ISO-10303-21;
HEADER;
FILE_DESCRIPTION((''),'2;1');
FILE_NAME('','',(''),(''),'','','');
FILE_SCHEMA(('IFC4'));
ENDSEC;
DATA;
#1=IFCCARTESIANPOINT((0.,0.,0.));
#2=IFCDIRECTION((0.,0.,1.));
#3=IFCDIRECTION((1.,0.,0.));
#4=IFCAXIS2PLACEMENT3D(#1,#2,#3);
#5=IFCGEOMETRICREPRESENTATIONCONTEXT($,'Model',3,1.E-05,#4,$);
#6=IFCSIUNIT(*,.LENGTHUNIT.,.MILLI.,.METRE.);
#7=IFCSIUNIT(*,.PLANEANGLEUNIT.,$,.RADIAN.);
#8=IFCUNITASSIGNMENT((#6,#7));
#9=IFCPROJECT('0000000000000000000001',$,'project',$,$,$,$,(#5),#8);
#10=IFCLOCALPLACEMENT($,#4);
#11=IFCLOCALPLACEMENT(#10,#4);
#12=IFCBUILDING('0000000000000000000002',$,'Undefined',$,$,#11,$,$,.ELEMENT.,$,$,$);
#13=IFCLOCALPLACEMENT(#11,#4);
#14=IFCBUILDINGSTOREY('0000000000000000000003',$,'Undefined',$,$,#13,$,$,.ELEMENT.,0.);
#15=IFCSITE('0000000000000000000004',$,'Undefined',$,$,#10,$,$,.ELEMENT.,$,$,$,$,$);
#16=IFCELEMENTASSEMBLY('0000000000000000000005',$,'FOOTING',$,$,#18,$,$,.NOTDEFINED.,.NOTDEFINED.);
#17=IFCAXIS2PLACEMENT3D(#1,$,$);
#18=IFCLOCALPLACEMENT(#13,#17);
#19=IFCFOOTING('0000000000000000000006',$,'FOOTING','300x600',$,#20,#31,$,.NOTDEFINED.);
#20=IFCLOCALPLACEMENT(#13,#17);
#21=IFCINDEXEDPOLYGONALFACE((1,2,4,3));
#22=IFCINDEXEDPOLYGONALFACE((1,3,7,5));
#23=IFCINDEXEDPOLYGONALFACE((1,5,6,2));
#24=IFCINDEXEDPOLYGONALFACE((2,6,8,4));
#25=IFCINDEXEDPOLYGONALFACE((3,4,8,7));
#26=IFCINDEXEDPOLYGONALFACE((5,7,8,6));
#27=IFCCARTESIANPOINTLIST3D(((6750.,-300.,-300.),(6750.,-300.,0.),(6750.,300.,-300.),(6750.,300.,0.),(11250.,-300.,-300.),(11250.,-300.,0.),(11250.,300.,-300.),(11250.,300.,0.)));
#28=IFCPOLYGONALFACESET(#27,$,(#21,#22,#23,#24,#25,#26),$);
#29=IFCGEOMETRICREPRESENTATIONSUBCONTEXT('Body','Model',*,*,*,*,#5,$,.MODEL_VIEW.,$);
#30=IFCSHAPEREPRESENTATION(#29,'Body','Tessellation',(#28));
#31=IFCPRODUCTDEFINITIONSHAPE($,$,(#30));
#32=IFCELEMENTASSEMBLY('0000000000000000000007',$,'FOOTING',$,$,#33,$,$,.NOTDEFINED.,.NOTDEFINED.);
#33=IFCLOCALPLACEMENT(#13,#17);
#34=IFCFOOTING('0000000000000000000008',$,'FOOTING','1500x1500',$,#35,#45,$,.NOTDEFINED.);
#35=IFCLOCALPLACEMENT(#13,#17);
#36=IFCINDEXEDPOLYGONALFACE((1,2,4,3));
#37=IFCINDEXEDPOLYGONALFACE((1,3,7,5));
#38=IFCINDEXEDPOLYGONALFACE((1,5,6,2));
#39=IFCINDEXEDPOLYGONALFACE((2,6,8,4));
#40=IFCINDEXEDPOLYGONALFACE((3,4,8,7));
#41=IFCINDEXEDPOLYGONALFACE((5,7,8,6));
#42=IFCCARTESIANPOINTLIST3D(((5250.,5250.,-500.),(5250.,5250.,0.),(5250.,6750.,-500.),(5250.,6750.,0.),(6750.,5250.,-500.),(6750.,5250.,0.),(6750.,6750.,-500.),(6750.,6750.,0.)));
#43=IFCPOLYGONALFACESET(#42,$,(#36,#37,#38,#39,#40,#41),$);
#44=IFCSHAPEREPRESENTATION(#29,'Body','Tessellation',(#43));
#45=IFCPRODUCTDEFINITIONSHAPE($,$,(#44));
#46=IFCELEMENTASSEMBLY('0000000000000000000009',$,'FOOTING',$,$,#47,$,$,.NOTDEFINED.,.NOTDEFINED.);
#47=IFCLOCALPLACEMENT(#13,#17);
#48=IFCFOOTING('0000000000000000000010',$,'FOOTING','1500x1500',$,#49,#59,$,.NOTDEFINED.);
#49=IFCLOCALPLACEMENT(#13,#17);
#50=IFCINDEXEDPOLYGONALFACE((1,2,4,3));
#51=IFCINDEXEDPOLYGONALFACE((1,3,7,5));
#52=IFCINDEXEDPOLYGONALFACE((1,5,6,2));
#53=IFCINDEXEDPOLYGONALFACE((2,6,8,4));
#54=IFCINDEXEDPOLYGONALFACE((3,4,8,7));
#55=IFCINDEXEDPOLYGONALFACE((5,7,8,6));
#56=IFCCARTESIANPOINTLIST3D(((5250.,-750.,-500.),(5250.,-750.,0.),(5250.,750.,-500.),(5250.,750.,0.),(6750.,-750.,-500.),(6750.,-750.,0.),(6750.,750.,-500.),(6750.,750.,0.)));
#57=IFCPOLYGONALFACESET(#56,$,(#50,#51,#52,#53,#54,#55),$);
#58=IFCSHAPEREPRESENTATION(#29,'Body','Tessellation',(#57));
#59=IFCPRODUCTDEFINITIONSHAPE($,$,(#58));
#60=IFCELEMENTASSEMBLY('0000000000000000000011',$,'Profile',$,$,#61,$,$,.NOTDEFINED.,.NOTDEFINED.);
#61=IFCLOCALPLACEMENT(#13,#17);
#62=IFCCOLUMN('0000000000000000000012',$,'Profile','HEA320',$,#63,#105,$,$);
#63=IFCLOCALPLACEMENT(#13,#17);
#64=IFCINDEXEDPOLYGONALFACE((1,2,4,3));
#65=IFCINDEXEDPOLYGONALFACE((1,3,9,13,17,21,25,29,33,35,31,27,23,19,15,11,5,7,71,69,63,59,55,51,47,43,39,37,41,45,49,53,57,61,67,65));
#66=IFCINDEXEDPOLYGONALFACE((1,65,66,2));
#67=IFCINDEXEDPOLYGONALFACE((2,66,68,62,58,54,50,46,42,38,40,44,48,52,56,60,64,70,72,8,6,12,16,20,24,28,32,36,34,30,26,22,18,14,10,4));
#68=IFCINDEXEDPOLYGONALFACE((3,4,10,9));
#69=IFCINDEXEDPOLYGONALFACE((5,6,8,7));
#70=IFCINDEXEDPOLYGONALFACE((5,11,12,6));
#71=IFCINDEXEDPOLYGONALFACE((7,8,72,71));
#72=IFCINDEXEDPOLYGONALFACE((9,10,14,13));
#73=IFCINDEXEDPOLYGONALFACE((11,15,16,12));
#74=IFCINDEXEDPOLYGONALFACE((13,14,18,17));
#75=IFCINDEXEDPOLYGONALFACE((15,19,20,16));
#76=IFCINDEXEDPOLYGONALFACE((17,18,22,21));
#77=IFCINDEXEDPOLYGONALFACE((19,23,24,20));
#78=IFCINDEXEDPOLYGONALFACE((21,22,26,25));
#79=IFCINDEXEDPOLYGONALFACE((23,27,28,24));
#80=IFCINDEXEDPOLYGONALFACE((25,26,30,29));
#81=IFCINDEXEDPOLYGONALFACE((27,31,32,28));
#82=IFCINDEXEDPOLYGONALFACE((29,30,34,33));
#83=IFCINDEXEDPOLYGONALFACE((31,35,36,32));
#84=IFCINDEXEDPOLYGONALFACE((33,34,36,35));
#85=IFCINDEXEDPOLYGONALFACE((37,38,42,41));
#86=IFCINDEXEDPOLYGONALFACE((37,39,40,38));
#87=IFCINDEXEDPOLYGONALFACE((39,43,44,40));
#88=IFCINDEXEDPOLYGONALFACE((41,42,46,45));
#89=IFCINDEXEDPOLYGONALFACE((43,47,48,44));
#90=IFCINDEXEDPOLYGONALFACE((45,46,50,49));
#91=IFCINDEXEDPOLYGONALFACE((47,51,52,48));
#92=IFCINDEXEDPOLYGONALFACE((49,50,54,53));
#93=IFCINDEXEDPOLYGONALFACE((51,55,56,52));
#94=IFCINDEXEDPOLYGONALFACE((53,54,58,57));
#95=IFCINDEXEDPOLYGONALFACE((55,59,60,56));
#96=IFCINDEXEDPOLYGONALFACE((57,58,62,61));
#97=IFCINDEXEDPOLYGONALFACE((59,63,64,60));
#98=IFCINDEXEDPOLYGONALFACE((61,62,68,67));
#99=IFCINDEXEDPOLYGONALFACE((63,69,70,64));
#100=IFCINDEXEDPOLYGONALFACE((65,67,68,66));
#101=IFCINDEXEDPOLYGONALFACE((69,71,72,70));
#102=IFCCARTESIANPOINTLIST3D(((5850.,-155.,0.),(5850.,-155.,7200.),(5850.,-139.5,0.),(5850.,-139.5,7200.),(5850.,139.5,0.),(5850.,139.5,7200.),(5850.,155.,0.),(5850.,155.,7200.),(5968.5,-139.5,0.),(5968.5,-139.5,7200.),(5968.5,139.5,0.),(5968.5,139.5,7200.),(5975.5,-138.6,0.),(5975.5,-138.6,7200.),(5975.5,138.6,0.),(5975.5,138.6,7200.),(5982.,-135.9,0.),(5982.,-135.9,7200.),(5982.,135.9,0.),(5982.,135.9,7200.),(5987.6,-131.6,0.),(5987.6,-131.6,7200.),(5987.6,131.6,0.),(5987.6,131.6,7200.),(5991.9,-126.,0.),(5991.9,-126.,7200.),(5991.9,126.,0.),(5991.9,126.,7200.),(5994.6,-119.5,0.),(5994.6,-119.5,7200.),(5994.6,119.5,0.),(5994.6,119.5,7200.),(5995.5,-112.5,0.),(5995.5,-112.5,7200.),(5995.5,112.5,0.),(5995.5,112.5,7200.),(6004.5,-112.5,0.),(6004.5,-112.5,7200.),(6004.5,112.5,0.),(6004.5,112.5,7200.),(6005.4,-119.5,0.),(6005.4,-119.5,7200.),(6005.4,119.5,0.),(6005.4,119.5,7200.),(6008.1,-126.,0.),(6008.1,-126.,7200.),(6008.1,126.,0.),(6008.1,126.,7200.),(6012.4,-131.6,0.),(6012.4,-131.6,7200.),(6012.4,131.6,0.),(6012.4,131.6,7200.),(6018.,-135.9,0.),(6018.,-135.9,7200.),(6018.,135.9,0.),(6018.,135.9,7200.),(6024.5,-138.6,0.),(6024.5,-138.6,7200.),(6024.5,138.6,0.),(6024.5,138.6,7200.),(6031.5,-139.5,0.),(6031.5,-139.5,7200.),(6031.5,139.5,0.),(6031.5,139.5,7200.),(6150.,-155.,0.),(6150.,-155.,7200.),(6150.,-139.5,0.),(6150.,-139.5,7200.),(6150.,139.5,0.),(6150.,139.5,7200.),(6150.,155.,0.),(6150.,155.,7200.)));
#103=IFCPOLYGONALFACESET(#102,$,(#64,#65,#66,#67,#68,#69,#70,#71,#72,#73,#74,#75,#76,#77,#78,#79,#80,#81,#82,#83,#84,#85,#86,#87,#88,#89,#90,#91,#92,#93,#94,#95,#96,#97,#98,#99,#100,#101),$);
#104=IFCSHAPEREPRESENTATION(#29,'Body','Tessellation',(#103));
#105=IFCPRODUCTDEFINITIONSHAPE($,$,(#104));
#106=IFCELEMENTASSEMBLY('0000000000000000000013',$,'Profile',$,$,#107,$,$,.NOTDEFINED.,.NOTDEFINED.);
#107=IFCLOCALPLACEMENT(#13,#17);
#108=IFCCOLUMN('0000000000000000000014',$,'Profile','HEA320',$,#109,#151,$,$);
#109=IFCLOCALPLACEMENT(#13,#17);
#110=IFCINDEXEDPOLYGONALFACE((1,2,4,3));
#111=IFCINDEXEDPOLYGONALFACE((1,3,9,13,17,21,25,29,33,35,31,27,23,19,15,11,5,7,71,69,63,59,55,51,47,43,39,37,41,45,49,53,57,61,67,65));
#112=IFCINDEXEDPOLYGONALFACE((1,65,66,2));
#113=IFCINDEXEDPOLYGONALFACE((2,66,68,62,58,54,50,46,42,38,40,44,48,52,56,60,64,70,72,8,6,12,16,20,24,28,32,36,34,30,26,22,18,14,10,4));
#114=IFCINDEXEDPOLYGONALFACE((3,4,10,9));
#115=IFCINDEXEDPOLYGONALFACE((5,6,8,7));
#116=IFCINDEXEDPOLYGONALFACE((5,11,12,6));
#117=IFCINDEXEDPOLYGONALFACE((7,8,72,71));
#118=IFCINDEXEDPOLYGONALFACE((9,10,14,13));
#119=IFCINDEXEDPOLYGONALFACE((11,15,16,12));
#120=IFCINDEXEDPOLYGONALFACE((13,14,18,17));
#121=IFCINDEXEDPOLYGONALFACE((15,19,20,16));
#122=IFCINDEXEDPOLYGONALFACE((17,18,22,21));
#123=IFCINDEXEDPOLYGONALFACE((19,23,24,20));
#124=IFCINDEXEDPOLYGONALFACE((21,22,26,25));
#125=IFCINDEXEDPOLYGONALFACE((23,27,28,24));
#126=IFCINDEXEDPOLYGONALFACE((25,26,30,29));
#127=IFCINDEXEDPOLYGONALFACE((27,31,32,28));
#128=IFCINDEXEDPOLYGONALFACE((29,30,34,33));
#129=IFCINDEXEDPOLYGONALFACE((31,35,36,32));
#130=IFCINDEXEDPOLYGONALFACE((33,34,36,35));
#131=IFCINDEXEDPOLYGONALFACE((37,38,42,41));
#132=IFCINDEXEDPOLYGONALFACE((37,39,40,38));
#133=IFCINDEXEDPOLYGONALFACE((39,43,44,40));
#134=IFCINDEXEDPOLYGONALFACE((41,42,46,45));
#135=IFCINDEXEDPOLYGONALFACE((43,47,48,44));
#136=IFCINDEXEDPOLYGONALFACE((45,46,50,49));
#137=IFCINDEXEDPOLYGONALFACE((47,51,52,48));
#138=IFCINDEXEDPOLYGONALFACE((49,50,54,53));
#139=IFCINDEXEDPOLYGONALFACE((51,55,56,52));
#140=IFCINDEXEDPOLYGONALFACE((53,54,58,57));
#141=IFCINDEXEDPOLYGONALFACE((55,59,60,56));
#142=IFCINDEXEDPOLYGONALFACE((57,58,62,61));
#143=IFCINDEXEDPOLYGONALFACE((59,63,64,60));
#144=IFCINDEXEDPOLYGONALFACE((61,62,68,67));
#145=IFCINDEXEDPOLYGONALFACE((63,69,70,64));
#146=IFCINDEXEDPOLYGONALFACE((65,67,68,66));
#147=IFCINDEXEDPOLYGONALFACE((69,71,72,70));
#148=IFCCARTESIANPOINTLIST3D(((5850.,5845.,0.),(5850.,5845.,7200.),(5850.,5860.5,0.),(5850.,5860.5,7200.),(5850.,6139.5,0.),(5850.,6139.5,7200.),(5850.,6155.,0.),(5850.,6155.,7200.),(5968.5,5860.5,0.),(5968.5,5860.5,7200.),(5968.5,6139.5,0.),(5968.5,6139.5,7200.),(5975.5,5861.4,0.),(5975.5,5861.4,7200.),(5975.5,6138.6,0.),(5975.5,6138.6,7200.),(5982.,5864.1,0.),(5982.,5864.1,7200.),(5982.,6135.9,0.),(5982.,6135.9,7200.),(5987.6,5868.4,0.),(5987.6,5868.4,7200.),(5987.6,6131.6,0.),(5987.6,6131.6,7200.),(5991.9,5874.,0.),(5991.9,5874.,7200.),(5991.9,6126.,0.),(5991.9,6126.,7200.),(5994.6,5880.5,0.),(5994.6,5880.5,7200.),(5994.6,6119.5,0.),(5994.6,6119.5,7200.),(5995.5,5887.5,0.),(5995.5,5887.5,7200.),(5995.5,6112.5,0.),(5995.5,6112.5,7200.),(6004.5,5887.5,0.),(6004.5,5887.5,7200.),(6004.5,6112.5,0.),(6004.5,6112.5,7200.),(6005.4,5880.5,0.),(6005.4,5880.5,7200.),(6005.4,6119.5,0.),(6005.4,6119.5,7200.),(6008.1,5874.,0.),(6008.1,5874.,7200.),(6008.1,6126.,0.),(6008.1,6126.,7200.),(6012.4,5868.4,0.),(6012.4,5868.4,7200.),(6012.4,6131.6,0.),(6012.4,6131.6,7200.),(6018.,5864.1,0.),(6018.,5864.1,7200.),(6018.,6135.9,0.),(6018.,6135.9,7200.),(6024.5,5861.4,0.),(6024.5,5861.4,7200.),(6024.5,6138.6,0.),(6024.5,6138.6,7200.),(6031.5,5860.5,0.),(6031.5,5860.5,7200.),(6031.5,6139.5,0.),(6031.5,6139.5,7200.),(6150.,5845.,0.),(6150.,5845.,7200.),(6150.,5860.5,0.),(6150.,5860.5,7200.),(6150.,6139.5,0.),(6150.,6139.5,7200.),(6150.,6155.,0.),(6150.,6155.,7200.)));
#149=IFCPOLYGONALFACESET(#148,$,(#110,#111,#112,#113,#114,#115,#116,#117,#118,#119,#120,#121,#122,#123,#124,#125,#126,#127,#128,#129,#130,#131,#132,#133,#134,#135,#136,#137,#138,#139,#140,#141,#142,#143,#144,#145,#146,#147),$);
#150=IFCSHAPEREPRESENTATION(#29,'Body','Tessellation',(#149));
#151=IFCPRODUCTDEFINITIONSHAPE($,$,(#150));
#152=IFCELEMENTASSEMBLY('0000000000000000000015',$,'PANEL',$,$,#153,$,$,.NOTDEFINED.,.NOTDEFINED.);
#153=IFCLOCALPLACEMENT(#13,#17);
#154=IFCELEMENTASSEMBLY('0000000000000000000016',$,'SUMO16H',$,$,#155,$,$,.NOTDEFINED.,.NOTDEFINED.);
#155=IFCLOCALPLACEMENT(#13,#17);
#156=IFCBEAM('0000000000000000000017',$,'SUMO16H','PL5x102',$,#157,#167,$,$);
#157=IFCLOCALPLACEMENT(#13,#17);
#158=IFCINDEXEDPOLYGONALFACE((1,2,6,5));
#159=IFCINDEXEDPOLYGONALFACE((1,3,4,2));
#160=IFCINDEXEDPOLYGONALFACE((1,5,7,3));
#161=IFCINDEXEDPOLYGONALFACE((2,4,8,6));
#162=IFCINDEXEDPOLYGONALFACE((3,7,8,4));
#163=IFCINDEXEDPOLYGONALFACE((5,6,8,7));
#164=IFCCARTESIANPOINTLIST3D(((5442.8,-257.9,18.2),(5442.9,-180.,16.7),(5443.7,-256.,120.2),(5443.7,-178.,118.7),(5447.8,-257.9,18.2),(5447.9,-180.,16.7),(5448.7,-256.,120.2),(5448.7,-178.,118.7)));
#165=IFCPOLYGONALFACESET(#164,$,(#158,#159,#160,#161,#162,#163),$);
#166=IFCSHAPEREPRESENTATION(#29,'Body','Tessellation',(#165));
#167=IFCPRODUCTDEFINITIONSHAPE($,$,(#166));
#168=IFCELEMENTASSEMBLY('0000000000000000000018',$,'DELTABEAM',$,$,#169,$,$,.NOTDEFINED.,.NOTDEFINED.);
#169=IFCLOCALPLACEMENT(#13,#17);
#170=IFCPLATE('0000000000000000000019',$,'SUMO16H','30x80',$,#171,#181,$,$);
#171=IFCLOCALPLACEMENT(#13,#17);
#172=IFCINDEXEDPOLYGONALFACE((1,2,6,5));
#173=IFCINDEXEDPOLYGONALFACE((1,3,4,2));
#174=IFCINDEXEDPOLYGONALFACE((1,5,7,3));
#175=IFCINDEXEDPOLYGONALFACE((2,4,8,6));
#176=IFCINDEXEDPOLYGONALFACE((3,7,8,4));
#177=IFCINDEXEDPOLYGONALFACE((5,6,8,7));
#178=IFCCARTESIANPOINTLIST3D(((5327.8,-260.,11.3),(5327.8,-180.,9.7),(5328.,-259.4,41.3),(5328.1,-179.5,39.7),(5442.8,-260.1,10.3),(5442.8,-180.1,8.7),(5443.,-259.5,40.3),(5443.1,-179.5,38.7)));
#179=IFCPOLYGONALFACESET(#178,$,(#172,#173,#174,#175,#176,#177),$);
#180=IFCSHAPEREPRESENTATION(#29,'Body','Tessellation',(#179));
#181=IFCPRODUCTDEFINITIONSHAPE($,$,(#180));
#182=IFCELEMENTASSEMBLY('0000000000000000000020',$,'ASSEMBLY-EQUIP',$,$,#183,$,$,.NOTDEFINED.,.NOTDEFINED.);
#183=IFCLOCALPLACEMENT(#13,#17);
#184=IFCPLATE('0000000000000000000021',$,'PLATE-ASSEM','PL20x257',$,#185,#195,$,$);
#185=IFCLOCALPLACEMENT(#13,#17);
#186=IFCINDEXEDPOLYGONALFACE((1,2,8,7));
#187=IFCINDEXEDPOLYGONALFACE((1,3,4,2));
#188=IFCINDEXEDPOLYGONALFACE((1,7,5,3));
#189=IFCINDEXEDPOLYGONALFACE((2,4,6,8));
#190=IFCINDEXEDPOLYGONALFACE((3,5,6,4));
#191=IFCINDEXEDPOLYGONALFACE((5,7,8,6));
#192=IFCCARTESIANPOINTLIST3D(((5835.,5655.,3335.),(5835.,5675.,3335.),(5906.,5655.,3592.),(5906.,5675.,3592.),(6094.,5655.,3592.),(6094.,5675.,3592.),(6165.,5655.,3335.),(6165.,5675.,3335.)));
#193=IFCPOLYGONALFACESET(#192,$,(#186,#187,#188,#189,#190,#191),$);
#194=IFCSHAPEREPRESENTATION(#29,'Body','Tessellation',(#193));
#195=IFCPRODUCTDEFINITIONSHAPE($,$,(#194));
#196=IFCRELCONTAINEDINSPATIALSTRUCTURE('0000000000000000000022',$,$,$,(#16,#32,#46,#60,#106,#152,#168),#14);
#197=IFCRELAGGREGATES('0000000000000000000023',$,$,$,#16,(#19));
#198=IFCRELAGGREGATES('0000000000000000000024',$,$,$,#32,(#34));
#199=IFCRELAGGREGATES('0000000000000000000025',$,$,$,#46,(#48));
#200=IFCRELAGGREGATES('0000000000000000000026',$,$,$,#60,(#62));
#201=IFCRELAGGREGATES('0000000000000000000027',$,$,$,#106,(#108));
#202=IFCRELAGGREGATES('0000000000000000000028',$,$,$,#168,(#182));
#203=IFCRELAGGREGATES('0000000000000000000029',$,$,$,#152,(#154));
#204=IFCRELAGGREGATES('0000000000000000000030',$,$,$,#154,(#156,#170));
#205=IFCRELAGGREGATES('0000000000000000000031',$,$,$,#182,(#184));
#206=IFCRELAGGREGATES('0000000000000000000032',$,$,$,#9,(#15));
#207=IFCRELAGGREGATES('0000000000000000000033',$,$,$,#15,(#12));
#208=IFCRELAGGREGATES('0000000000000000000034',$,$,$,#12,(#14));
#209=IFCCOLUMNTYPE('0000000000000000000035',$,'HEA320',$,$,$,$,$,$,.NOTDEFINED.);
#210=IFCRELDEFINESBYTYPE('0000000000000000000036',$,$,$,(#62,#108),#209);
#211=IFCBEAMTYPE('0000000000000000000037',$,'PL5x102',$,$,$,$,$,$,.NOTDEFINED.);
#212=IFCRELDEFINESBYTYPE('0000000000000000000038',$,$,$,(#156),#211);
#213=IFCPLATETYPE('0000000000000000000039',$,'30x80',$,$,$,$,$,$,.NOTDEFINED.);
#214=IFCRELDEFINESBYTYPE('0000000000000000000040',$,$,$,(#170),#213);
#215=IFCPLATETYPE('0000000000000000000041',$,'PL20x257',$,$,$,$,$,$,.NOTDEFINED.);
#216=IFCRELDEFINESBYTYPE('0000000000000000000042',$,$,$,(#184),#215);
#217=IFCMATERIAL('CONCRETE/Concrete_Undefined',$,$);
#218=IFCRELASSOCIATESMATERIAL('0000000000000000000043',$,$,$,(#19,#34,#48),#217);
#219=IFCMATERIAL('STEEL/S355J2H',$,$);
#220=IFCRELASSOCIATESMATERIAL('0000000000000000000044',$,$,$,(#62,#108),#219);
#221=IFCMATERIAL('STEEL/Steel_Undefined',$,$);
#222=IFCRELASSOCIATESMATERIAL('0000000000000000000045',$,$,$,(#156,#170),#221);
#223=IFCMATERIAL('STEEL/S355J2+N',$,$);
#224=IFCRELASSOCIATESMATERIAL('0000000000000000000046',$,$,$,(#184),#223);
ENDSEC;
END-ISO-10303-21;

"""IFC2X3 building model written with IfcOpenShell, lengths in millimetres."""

from ifc_helpers import new_model, si_unit, frame, origin_with_axes, origin_2d_with_axis, place, context, subcontext, project, spatial, polyline, rectangle, i_section, outline, extrude, material, type_object, element, aggregate, save


model = new_model("IFC2X3")

# Units and contexts
model_context = context("Model", 3, precision=1e-05, world=origin_with_axes())
body_context = subcontext(model_context, "Body", "Model", "MODEL_VIEW")
ifc_project = project(units=[si_unit("LENGTHUNIT", "METRE", prefix="MILLI"), si_unit("PLANEANGLEUNIT", "RADIAN")], contexts=[model_context])

# Site, building, storey
site_placement = place(None, origin_with_axes())
site = spatial("IfcSite", under=ifc_project, at=site_placement, Name="Undefined", CompositionType="ELEMENT")
building_placement = place(site_placement, origin_with_axes())
building = spatial("IfcBuilding", under=site, at=building_placement, Name="Undefined", CompositionType="ELEMENT")
storey_placement = place(building_placement, origin_with_axes())
storey = spatial("IfcBuildingStorey", under=building, at=storey_placement, Name="Undefined", CompositionType="ELEMENT", Elevation=0.0)

# Element assemblies, footings
assembly_1_placement = place(storey_placement, origin_with_axes())
assembly_1 = element("IfcElementAssembly", 1, at=assembly_1_placement, inside=storey, Name="FOOTING", AssemblyPlace="NOTDEFINED", PredefinedType="NOTDEFINED")
ifc_material_1 = material(Name="CONCRETE/Concrete_Undefined")
footing_1_placement = place(assembly_1_placement, frame((6750.0, 0.0, -150.0), z_axis=(0.0, 0.0, 1.0), x_axis=(1.0, 0.0, 0.0)))
footing_1 = element("IfcFooting", 2, at=footing_1_placement, material=ifc_material_1, Name="FOOTING", Description="300x600", PredefinedType="NOTDEFINED", context=body_context, shape_type="SweptSolid", body=[
    extrude(rectangle(XDim=600.0, YDim=300.0, at=origin_2d_with_axis()), frame((4500.0, 0.0, 0.0), z_axis=(-1.0, 0.0, 0.0), x_axis=(0.0, -1.0, 0.0)), (0.0, 0.0, 1.0), 4500.0),
])
aggregate(assembly_1, [footing_1])
assembly_2_placement = place(storey_placement, origin_with_axes())
assembly_2 = element("IfcElementAssembly", 3, at=assembly_2_placement, inside=storey, Name="FOOTING", AssemblyPlace="NOTDEFINED", PredefinedType="NOTDEFINED")
footing_2_placement = place(assembly_2_placement, frame((6000.0, 6000.0, -500.0), z_axis=(0.0, 1.0, 0.0), x_axis=(0.0, 0.0, 1.0)))
footing_2 = element("IfcFooting", 4, at=footing_2_placement, material=ifc_material_1, Name="FOOTING", Description="1500x1500", PredefinedType="NOTDEFINED", context=body_context, shape_type="SweptSolid", body=[
    extrude(rectangle(XDim=1500.0, YDim=1500.0, at=origin_2d_with_axis()), frame((500.0, 0.0, 0.0), z_axis=(-1.0, 0.0, 0.0), x_axis=(0.0, -1.0, 0.0)), (0.0, 0.0, 1.0), 500.0),
])
aggregate(assembly_2, [footing_2])
assembly_3_placement = place(storey_placement, origin_with_axes())
assembly_3 = element("IfcElementAssembly", 5, at=assembly_3_placement, inside=storey, Name="FOOTING", AssemblyPlace="NOTDEFINED", PredefinedType="NOTDEFINED")
footing_3_placement = place(assembly_3_placement, frame((6000.0, 0.0, -500.0), z_axis=(0.0, 1.0, 0.0), x_axis=(0.0, 0.0, 1.0)))
footing_3 = element("IfcFooting", 6, at=footing_3_placement, material=ifc_material_1, Name="FOOTING", Description="1500x1500", PredefinedType="NOTDEFINED", context=body_context, shape_type="SweptSolid", body=[
    extrude(rectangle(XDim=1500.0, YDim=1500.0, at=origin_2d_with_axis()), frame((500.0, 0.0, 0.0), z_axis=(-1.0, 0.0, 0.0), x_axis=(0.0, -1.0, 0.0)), (0.0, 0.0, 1.0), 500.0),
])
aggregate(assembly_3, [footing_3])

# Element assemblies, columns
assembly_4_placement = place(storey_placement, origin_with_axes())
assembly_4 = element("IfcElementAssembly", 7, at=assembly_4_placement, inside=storey, Name="Profile", AssemblyPlace="NOTDEFINED", PredefinedType="NOTDEFINED")
ifc_material_2 = material(Name="STEEL/S355J2H")
column_type = type_object("IfcColumnType", Name="HEA320", PredefinedType="NOTDEFINED")
column_1_placement = place(assembly_4_placement, frame((6000.0, 0.0, 0.0), z_axis=(0.0, 0.0, 1.0), x_axis=(0.0, 1.0, 0.0)))
column_1 = element("IfcColumn", 8, at=column_1_placement, type_object=column_type, material=ifc_material_2, Name="Profile", Description="HEA320", context=body_context, shape_type="SweptSolid", body=[
    extrude(i_section(OverallWidth=300.0, OverallDepth=310.0, WebThickness=9.0, FlangeThickness=15.5, FilletRadius=27.0, at=origin_2d_with_axis()), frame((0.0, 0.0, 7200.0), z_axis=(0.0, 0.0, -1.0), x_axis=(0.0, 1.0, 0.0)), (0.0, 0.0, 1.0), 7200.0),
])
aggregate(assembly_4, [column_1])
assembly_5_placement = place(storey_placement, origin_with_axes())
assembly_5 = element("IfcElementAssembly", 9, at=assembly_5_placement, inside=storey, Name="Profile", AssemblyPlace="NOTDEFINED", PredefinedType="NOTDEFINED")
column_2_placement = place(assembly_5_placement, frame((6000.0, 6000.0, 0.0), z_axis=(0.0, 0.0, 1.0), x_axis=(0.0, 1.0, 0.0)))
column_2 = element("IfcColumn", 10, at=column_2_placement, type_object=column_type, material=ifc_material_2, Name="Profile", Description="HEA320", context=body_context, shape_type="SweptSolid", body=[
    extrude(i_section(OverallWidth=300.0, OverallDepth=310.0, WebThickness=9.0, FlangeThickness=15.5, FilletRadius=27.0, at=origin_2d_with_axis()), frame((0.0, 0.0, 7200.0), z_axis=(0.0, 0.0, -1.0), x_axis=(0.0, 1.0, 0.0)), (0.0, 0.0, 1.0), 7200.0),
])
aggregate(assembly_5, [column_2])

# Element assemblies, beam
assembly_6_placement = place(storey_placement, origin_with_axes())
assembly_6 = element("IfcElementAssembly", 11, at=assembly_6_placement, inside=storey, Name="PANEL", AssemblyPlace="NOTDEFINED", PredefinedType="NOTDEFINED")
assembly_7_placement = place(assembly_6_placement, origin_with_axes())
assembly_7 = element("IfcElementAssembly", 12, at=assembly_7_placement, Name="SUMO16H", AssemblyPlace="NOTDEFINED", PredefinedType="NOTDEFINED")
ifc_material_3 = material(Name="STEEL/Steel_Undefined")
beam_type_1 = type_object("IfcBeamType", Name="PL5x102", PredefinedType="NOTDEFINED")
beam_1_placement = place(assembly_7_placement, frame((5445.8, -179.0, 67.7), z_axis=(0.008618, 0.019092, 0.999781), x_axis=(-0.000494, -0.999818, 0.019097)))
beam_1 = element("IfcBeam", 13, at=beam_1_placement, type_object=beam_type_1, material=ifc_material_3, Name="SUMO16H", Description="PL5x102", context=body_context, shape_type="SweptSolid", body=[
    extrude(rectangle(XDim=5.0, YDim=102.0, at=origin_2d_with_axis()), frame((78.0, 0.0, 0.0), z_axis=(-1.0, 0.0, 0.0), x_axis=(0.0, -1.0, 0.0)), (0.0, 0.0, 1.0), 78.0),
])

# Element assembly
assembly_8_placement = place(storey_placement, origin_with_axes())
assembly_8 = element("IfcElementAssembly", 14, at=assembly_8_placement, inside=storey, Name="DELTABEAM", AssemblyPlace="NOTDEFINED", PredefinedType="NOTDEFINED")

# Plate
plate_type_1 = type_object("IfcPlateType", Name="30x80", PredefinedType="NOTDEFINED")
plate_1_placement = place(assembly_7_placement, frame((5442.9, -179.8, 23.7), z_axis=(0.008618, 0.019092, 0.999781), x_axis=(-0.999963, 0.000658, 0.008607)))
plate_1 = element("IfcPlate", 15, at=plate_1_placement, type_object=plate_type_1, material=ifc_material_3, Name="SUMO16H", Description="30x80", context=body_context, shape_type="SweptSolid", body=[
    extrude(outline(polyline([(0.0, 0.0), (115.0, 0.0), (115.0, 80.0), (0.0, 80.0), (0.0, 0.0)])), frame((0.0, 0.0, -15.0), z_axis=(0.0, 0.0, 1.0), x_axis=(1.0, 0.0, 0.0)), (0.0, 0.0, 1.0), 30.0),
])

# Element assembly, plate
assembly_9_placement = place(assembly_8_placement, origin_with_axes())
assembly_9 = element("IfcElementAssembly", 16, at=assembly_9_placement, Name="ASSEMBLY-EQUIP", AssemblyPlace="NOTDEFINED", PredefinedType="NOTDEFINED")
ifc_material_4 = material(Name="STEEL/S355J2+N")
plate_type_2 = type_object("IfcPlateType", Name="PL20x257", PredefinedType="NOTDEFINED")
plate_2_placement = place(assembly_9_placement, frame((5835.0, 5665.0, 3335.0), z_axis=(0.0, -1.0, 0.0), x_axis=(1.0, 0.0, 0.0)))
plate_2 = element("IfcPlate", 17, at=plate_2_placement, type_object=plate_type_2, material=ifc_material_4, Name="PLATE-ASSEM", Description="PL20x257", context=body_context, shape_type="SweptSolid", body=[
    extrude(outline(polyline([(0.0, 0.0), (330.0, 0.0), (259.0, 257.0), (71.0, 257.0), (0.0, 0.0)])), frame((0.0, 0.0, -10.0), z_axis=(0.0, 0.0, 1.0), x_axis=(1.0, 0.0, 0.0)), (0.0, 0.0, 1.0), 20.0),
])

aggregate(assembly_8, [assembly_9])

aggregate(assembly_6, [assembly_7])

aggregate(assembly_7, [beam_1, plate_1])

aggregate(assembly_9, [plate_2])

save(model, "model.ifc")
